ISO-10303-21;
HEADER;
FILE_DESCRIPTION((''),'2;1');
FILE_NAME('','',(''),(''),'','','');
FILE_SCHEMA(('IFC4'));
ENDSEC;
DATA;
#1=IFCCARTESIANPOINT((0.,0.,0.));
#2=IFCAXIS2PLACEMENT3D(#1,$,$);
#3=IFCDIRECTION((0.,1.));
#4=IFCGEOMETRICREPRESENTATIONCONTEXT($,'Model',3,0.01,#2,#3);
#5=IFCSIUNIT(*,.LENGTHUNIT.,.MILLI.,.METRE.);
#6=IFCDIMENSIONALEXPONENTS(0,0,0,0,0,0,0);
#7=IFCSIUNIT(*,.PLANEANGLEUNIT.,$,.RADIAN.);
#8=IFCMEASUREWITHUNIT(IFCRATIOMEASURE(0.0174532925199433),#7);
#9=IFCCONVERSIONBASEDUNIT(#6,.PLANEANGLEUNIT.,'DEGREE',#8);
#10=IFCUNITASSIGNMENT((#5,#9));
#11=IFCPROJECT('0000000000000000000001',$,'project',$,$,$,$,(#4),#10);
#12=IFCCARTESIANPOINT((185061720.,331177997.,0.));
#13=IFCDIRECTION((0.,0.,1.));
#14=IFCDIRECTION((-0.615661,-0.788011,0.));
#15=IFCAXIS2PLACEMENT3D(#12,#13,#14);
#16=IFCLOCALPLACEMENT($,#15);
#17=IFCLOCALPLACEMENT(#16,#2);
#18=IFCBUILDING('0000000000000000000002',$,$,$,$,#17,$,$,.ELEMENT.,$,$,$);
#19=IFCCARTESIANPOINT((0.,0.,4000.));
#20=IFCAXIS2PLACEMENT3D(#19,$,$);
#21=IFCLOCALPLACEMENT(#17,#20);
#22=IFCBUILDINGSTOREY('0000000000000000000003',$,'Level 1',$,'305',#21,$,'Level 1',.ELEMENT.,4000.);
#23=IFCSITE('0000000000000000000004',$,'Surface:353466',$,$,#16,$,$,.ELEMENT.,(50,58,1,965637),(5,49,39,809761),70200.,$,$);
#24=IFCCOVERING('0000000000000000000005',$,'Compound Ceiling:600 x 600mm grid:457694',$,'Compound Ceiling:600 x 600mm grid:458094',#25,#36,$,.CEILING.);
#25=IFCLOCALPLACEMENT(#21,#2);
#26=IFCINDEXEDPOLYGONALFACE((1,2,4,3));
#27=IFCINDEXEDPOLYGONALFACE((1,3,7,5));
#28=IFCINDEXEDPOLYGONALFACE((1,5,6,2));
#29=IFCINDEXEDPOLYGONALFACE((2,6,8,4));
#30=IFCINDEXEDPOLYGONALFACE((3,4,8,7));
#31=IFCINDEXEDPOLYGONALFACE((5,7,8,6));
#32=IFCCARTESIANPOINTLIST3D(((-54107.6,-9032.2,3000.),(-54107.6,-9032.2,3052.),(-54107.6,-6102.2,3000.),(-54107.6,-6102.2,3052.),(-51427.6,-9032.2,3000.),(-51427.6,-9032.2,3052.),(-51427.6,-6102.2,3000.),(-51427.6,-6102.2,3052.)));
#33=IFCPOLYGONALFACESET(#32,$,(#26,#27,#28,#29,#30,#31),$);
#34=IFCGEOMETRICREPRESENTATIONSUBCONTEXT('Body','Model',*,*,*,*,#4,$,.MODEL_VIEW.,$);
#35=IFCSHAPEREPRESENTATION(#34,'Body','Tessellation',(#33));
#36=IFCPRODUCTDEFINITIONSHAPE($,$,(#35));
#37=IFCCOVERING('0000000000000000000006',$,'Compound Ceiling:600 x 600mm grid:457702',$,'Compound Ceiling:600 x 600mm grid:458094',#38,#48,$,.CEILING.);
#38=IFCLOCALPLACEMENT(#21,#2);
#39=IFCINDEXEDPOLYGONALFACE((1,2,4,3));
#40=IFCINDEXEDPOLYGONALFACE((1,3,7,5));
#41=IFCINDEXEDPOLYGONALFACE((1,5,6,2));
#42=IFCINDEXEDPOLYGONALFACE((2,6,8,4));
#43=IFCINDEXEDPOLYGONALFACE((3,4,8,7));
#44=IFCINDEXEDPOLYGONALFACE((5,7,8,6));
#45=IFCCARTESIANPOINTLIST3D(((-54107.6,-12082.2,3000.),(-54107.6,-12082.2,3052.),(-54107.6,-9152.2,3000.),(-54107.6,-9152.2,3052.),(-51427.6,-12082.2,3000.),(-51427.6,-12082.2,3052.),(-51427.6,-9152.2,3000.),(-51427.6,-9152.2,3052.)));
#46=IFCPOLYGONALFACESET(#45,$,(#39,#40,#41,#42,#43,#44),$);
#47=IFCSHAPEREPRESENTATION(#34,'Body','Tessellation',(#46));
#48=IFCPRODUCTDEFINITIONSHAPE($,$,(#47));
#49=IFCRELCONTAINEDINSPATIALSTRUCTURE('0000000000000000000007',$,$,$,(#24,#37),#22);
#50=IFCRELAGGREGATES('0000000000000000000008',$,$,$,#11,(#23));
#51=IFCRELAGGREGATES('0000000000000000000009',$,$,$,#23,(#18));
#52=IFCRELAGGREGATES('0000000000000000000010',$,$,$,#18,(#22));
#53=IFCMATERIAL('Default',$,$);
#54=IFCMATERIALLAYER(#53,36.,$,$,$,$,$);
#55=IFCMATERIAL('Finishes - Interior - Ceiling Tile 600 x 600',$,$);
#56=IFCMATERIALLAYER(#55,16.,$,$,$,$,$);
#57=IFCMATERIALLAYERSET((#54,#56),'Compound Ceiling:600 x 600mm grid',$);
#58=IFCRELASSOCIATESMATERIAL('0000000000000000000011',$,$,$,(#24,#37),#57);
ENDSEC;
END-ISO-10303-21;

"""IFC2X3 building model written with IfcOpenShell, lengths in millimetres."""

from ifc_helpers import new_model, entity, si_unit, converted_unit, direction, frame, frame_2d, origin, origin_2d_with_axis, place, context, subcontext, project, spatial, rectangle, extrude, material, layer, layer_set, layer_usage, element, save


model = new_model("IFC2X3")

# Units and contexts
model_context = context("Model", 3, precision=0.01, world=origin(), true_north=direction((0.0, 1.0)))
body_context = subcontext(model_context, "Body", "Model", "MODEL_VIEW")
ifc_project = project(units=[si_unit("LENGTHUNIT", "METRE", prefix="MILLI"), converted_unit("PLANEANGLEUNIT", "DEGREE", entity("IfcRatioMeasure", 0.0174532925199433), si_unit("PLANEANGLEUNIT", "RADIAN"), dimensions=[0, 0, 0, 0, 0, 0, 0])], contexts=[model_context])

# Site, building, storey
site_placement = place(None, frame((185061720.0, 331177997.0, 0.0), z_axis=(0.0, 0.0, 1.0), x_axis=(-0.615661, -0.788011, 0.0)))
site = spatial("IfcSite", under=ifc_project, at=site_placement, Name="Surface:353466", CompositionType="ELEMENT", RefLatitude=(50, 58, 1, 965637), RefLongitude=(5, 49, 39, 809761), RefElevation=70200.0)
building_placement = place(site_placement, origin())
building = spatial("IfcBuilding", under=site, at=building_placement, CompositionType="ELEMENT")
storey_placement = place(building_placement, frame((0.0, 0.0, 4000.0)))
storey = spatial("IfcBuildingStorey", under=building, at=storey_placement, Name="Level 1", ObjectType="305", LongName="Level 1", CompositionType="ELEMENT", Elevation=4000.0)

# Coverings
ifc_material_1 = material(Name="Default")
ifc_layer_1 = layer(ifc_material_1, 36.0)
ifc_material_2 = material(Name="Finishes - Interior - Ceiling Tile 600 x 600")
ifc_layer_2 = layer(ifc_material_2, 16.0)
ifc_layer_set_1 = layer_set([ifc_layer_1, ifc_layer_2], Name="Compound Ceiling:600 x 600mm grid")
ifc_layer_usage_1 = layer_usage(ifc_layer_set_1, "AXIS3", "POSITIVE", 0.0)
covering_1_placement = place(storey_placement, frame((-54107.6, -9032.2, 3000.0)))
element("IfcCovering", 1, at=covering_1_placement, inside=storey, material=ifc_layer_usage_1, Name="Compound Ceiling:600 x 600mm grid:457694", ObjectType="Compound Ceiling:600 x 600mm grid:458094", PredefinedType="CEILING", context=body_context, shape_type="SweptSolid", body=[
    extrude(rectangle(XDim=2680.0, YDim=2930.0, at=frame_2d((0.0, 0.0), x_axis=(1.0, 0.0))), frame((1340.0, 1465.0, 0.0)), (0.0, 0.0, 1.0), 52.0),
])
ifc_layer_usage_2 = layer_usage(ifc_layer_set_1, "AXIS3", "POSITIVE", 0.0)
covering_2_placement = place(storey_placement, frame((-54107.6, -12082.2, 3000.0)))
element("IfcCovering", 2, at=covering_2_placement, inside=storey, material=ifc_layer_usage_2, Name="Compound Ceiling:600 x 600mm grid:457702", ObjectType="Compound Ceiling:600 x 600mm grid:458094", PredefinedType="CEILING", context=body_context, shape_type="SweptSolid", body=[
    extrude(rectangle(XDim=2930.0, YDim=2680.0, at=origin_2d_with_axis()), frame((1340.0, 1465.0, 0.0), z_axis=(0.0, 0.0, 1.0), x_axis=(0.0, 1.0, 0.0)), (0.0, 0.0, 1.0), 52.0),
])

save(model, "model.ifc")
